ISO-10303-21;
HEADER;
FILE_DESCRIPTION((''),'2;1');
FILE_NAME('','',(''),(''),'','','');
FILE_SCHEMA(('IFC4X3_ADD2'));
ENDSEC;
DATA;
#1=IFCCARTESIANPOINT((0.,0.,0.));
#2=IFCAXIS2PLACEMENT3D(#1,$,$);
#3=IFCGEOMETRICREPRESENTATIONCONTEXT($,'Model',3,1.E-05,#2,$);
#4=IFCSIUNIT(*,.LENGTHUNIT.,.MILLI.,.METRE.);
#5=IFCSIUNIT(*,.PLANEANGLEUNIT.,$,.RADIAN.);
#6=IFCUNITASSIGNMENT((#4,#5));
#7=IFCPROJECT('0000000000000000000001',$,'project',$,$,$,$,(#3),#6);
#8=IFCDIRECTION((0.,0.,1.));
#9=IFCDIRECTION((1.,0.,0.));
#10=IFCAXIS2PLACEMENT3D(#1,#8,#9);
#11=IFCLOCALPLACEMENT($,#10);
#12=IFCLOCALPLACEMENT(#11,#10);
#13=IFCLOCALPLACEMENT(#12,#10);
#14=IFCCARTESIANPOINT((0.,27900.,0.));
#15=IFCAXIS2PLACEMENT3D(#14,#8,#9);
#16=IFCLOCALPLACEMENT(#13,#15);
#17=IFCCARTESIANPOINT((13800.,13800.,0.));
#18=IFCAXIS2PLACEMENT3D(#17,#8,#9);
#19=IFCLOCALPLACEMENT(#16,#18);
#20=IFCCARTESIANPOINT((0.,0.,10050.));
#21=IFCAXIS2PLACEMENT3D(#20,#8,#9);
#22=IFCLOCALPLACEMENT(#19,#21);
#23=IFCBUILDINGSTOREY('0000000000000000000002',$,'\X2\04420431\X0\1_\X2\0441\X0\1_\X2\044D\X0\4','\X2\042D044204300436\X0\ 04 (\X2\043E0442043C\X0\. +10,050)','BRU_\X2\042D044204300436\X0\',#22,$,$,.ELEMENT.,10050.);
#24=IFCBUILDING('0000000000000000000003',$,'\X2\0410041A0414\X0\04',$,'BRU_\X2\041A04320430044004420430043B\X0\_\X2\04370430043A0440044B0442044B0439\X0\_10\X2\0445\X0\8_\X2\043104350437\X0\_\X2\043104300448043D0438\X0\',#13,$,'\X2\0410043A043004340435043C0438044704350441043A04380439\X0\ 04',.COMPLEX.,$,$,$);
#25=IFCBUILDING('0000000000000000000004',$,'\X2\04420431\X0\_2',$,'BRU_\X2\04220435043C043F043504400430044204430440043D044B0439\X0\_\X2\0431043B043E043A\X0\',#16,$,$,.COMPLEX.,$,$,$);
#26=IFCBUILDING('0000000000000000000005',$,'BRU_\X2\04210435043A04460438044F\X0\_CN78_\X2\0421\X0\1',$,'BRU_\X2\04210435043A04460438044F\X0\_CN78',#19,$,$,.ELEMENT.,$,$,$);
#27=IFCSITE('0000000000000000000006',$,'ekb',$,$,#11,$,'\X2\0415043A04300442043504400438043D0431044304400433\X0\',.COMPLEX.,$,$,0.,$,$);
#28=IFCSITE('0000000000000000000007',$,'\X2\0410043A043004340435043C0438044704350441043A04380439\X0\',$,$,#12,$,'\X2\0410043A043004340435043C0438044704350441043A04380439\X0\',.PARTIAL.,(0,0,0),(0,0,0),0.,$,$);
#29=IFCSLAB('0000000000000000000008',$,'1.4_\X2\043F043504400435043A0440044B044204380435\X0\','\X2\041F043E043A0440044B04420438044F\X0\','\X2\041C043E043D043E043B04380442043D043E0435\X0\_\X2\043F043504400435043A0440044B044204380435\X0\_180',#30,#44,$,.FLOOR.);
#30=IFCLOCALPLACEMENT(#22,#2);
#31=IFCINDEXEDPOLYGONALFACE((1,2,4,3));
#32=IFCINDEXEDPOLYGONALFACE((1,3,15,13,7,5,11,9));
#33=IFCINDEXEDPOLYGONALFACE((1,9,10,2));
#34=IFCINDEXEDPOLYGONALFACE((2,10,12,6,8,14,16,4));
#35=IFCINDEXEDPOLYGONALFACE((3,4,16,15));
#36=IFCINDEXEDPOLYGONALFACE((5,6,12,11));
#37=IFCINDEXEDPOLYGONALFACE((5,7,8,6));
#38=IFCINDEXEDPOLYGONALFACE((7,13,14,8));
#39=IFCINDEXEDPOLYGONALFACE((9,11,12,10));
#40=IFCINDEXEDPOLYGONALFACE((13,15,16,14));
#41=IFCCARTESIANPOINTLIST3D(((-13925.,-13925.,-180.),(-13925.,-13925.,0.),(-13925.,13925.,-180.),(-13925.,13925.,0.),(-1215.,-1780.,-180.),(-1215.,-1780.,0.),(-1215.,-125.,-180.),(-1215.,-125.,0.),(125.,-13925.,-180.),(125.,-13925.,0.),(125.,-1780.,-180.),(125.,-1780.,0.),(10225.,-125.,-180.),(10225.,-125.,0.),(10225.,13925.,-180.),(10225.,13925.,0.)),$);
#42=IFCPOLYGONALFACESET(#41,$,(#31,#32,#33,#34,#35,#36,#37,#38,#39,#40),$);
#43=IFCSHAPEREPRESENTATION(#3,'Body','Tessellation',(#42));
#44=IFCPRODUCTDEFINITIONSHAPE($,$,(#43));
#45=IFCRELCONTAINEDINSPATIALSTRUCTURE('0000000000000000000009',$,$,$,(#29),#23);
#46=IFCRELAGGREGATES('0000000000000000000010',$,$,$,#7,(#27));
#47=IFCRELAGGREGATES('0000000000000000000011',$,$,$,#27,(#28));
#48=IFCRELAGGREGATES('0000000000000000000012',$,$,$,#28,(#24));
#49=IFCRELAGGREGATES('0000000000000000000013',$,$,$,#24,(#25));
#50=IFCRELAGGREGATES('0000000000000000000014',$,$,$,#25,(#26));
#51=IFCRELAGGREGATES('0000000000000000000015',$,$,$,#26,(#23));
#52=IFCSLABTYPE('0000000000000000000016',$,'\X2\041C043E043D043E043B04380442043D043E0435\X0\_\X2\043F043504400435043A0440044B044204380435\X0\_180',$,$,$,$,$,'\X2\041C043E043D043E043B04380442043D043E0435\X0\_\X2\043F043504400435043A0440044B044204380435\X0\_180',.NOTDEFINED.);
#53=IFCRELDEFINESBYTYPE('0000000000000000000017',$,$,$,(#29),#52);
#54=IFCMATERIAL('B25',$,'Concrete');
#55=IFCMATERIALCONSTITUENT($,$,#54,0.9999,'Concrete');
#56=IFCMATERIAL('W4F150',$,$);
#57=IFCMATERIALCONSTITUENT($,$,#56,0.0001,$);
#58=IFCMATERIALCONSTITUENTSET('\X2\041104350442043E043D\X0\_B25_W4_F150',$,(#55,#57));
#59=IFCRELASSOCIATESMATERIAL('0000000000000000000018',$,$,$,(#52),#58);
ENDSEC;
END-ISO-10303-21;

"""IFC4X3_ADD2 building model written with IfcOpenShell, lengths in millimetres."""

from ifc_helpers import new_model, si_unit, frame, origin, origin_with_axes, place, context, project, spatial, polyline, outline, extrude, material, constituent, constituent_set, type_object, element, save


model = new_model("IFC4X3_ADD2")

# Units and contexts
model_context = context("Model", 3, precision=1e-05, world=origin())
ifc_project = project(units=[si_unit("LENGTHUNIT", "METRE", prefix="MILLI"), si_unit("PLANEANGLEUNIT", "RADIAN")], contexts=[model_context])

# Sites, buildings, storey
site_1_placement = place(None, origin_with_axes())
site_1 = spatial("IfcSite", under=ifc_project, at=site_1_placement, Name="ekb", LongName="Екатеринбург", CompositionType="COMPLEX", RefElevation=0.0)
site_2_placement = place(site_1_placement, origin_with_axes())
site_2 = spatial("IfcSite", under=site_1, at=site_2_placement, Name="Академический", LongName="Академический", CompositionType="PARTIAL", RefLatitude=(0, 0, 0), RefLongitude=(0, 0, 0), RefElevation=0.0)
building_1_placement = place(site_2_placement, origin_with_axes())
building_1 = spatial("IfcBuilding", under=site_2, at=building_1_placement, Name="АКД04", ObjectType="BRU_Квартал_закрытый_10х8_без_башни", LongName="Академический 04", CompositionType="COMPLEX")
building_2_placement = place(building_1_placement, frame((0.0, 27900.0, 0.0), z_axis=(0.0, 0.0, 1.0), x_axis=(1.0, 0.0, 0.0)))
building_2 = spatial("IfcBuilding", under=building_1, at=building_2_placement, Name="тб_2", ObjectType="BRU_Температурный_блок", CompositionType="COMPLEX")
building_3_placement = place(building_2_placement, frame((13800.0, 13800.0, 0.0), z_axis=(0.0, 0.0, 1.0), x_axis=(1.0, 0.0, 0.0)))
building_3 = spatial("IfcBuilding", under=building_2, at=building_3_placement, Name="BRU_Секция_CN78_С1", ObjectType="BRU_Секция_CN78", CompositionType="ELEMENT")
storey_placement = place(building_3_placement, frame((0.0, 0.0, 10050.0), z_axis=(0.0, 0.0, 1.0), x_axis=(1.0, 0.0, 0.0)))
storey = spatial("IfcBuildingStorey", under=building_3, at=storey_placement, Name="тб1_с1_э4", Description="Этаж 04 (отм. +10,050)", ObjectType="BRU_Этаж", CompositionType="ELEMENT", Elevation=10050.0)

# Shared definitions
ifc_material_1 = material(Name="B25", Category="Concrete")
ifc_material_2 = material(Name="W4F150")

# Slab
ifc_constituent_1 = constituent(ifc_material_1, Category="Concrete", fraction=0.9999)
ifc_constituent_2 = constituent(ifc_material_2, fraction=0.0001)
ifc_constituent_set_1 = constituent_set(constituents=[ifc_constituent_1, ifc_constituent_2], Name="Бетон_B25_W4_F150")
slab_type = type_object("IfcSlabType", Name="Монолитное_перекрытие_180", ElementType="Монолитное_перекрытие_180", PredefinedType="NOTDEFINED", material=ifc_constituent_set_1)
slab_placement = place(storey_placement, frame((0.0, 0.0, -180.0), z_axis=(0.0, 0.0, 1.0), x_axis=(1.0, 0.0, 0.0)))
element("IfcSlab", 1, at=slab_placement, inside=storey, type_object=slab_type, Name="1.4_перекрытие", Description="Покрытия", ObjectType="Монолитное_перекрытие_180", PredefinedType="FLOOR", context=model_context, shape_type="SweptSolid", body=[
    extrude(outline(polyline([(-13925.0, -13925.0), (125.0, -13925.0), (125.0, -1780.0), (-1215.0, -1780.0), (-1215.0, -125.0), (10225.0, -125.0), (10225.0, 13925.0), (-13925.0, 13925.0), (-13925.0, -13925.0)])), origin_with_axes(), (0.0, 0.0, 1.0), 180.0),
])

save(model, "model.ifc")
